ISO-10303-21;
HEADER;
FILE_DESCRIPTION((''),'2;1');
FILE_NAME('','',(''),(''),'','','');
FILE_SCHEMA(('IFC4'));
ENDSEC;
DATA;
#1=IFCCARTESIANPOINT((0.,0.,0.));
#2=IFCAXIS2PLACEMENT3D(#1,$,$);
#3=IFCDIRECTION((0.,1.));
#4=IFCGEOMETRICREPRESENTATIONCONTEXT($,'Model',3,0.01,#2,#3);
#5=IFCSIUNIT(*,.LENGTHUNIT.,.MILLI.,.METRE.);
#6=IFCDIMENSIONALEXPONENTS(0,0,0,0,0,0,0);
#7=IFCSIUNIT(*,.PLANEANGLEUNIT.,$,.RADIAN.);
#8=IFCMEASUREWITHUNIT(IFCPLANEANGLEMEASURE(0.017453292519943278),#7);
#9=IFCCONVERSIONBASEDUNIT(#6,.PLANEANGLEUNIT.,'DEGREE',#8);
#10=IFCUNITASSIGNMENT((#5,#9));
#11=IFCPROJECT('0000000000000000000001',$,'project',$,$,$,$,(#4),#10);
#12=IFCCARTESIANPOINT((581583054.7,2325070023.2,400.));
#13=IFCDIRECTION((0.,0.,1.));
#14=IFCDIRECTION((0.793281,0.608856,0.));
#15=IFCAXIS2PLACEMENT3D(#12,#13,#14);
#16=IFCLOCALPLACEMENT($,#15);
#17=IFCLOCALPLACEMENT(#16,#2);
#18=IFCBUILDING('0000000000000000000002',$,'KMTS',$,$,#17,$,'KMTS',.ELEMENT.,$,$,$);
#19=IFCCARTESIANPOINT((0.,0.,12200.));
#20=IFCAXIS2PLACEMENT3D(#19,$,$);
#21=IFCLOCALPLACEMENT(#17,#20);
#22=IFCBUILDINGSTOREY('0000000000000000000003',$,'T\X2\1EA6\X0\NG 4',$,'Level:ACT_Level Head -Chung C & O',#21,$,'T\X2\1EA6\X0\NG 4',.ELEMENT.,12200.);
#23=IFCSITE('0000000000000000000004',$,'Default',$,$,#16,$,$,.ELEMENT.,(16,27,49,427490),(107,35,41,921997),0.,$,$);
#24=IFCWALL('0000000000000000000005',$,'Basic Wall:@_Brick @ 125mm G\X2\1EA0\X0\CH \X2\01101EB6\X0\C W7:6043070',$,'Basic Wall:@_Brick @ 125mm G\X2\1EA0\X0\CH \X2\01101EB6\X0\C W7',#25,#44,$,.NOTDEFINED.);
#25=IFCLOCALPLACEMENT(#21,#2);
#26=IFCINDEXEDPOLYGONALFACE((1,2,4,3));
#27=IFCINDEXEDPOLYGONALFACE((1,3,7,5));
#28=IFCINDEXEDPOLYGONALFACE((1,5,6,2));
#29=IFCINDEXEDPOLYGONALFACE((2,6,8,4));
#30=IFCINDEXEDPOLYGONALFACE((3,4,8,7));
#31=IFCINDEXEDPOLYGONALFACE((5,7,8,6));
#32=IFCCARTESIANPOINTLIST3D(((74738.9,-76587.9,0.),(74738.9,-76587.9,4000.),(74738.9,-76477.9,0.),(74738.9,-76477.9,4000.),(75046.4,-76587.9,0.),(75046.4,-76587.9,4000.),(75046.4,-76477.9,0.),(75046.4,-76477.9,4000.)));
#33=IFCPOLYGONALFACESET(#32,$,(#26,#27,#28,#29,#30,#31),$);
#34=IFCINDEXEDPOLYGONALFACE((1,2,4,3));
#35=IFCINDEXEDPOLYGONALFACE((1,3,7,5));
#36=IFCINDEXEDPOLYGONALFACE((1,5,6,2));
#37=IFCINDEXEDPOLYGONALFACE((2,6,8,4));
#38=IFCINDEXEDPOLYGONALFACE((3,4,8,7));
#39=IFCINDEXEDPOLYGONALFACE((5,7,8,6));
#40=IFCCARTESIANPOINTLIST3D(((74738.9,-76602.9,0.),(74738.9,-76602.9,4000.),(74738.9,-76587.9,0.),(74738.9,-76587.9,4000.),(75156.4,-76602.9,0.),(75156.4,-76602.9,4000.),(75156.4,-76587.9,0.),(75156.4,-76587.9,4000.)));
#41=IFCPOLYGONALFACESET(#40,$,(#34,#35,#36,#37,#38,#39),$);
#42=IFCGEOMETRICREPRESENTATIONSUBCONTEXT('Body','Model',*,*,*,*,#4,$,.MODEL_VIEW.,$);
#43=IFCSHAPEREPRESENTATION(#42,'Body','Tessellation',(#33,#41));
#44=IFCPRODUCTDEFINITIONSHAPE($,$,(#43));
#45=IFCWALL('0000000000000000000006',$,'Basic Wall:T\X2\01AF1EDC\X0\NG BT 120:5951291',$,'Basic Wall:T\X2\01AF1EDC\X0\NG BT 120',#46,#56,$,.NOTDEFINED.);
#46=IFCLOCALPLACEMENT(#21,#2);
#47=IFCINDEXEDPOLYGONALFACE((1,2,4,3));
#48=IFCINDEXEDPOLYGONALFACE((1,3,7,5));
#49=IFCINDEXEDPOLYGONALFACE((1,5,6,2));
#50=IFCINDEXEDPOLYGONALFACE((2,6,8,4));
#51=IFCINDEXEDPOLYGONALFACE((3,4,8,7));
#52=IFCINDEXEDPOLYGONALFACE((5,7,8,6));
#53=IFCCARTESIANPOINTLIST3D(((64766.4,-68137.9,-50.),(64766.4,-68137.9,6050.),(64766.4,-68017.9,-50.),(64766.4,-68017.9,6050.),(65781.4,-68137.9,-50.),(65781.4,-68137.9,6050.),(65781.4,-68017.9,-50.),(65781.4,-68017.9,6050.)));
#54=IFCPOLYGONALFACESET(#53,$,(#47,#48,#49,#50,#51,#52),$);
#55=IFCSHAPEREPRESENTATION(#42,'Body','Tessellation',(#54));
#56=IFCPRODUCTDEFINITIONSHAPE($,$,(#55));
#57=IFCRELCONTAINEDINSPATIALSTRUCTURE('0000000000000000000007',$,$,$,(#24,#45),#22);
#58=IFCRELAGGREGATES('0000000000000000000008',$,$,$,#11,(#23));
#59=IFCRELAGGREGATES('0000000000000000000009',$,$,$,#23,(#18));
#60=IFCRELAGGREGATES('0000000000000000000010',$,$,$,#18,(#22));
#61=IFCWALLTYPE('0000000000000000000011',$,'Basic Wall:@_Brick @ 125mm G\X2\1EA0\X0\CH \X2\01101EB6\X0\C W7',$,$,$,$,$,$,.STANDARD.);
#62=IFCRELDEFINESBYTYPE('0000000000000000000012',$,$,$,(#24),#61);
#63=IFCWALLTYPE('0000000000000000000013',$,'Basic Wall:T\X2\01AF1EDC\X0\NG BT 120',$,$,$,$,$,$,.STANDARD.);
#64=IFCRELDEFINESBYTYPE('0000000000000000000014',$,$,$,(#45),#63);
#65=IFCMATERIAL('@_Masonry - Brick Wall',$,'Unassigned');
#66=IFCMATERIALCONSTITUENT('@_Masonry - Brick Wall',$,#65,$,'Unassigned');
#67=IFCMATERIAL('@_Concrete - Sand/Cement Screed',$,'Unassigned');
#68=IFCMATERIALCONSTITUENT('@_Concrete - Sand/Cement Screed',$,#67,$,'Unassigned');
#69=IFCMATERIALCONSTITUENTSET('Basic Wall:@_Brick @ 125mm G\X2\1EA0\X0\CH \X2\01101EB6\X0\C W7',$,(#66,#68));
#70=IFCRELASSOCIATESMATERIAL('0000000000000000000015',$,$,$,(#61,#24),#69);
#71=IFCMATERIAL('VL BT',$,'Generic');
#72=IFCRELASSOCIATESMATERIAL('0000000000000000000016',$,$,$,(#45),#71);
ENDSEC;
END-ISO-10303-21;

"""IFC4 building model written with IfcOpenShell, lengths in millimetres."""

from ifc_helpers import new_model, entity, si_unit, converted_unit, direction, frame, origin, place, context, subcontext, project, spatial, indexed_curve, outline, extrude, material, constituent, constituent_set, type_object, element, save


model = new_model("IFC4")

# Units and contexts
model_context = context("Model", 3, precision=0.01, world=origin(), true_north=direction((0.0, 1.0)))
body_context = subcontext(model_context, "Body", "Model", "MODEL_VIEW")
ifc_project = project(units=[si_unit("LENGTHUNIT", "METRE", prefix="MILLI"), converted_unit("PLANEANGLEUNIT", "DEGREE", entity("IfcPlaneAngleMeasure", 0.017453292519943278), si_unit("PLANEANGLEUNIT", "RADIAN"), dimensions=[0, 0, 0, 0, 0, 0, 0])], contexts=[model_context])

# Site, building, storey
site_placement = place(None, frame((581583054.7, 2325070023.2, 400.0), z_axis=(0.0, 0.0, 1.0), x_axis=(0.793281, 0.608856, 0.0)))
site = spatial("IfcSite", under=ifc_project, at=site_placement, Name="Default", CompositionType="ELEMENT", RefLatitude=(16, 27, 49, 427490), RefLongitude=(107, 35, 41, 921997), RefElevation=0.0)
building_placement = place(site_placement, origin())
building = spatial("IfcBuilding", under=site, at=building_placement, Name="KMTS", LongName="KMTS", CompositionType="ELEMENT")
storey_placement = place(building_placement, frame((0.0, 0.0, 12200.0)))
storey = spatial("IfcBuildingStorey", under=building, at=storey_placement, Name="TẦNG 4", ObjectType="Level:ACT_Level Head -Chung C & O", LongName="TẦNG 4", CompositionType="ELEMENT", Elevation=12200.0)

# Shared definitions
ifc_material_1 = material(Name="VL BT", Category="Generic")

# Walls
ifc_material_2 = material(Name="@_Masonry - Brick Wall", Category="Unassigned")
ifc_constituent_1 = constituent(ifc_material_2, Name="@_Masonry - Brick Wall", Category="Unassigned")
ifc_material_3 = material(Name="@_Concrete - Sand/Cement Screed", Category="Unassigned")
ifc_constituent_2 = constituent(ifc_material_3, Name="@_Concrete - Sand/Cement Screed", Category="Unassigned")
ifc_constituent_set_1 = constituent_set(constituents=[ifc_constituent_1, ifc_constituent_2], Name="Basic Wall:@_Brick @ 125mm GẠCH ĐẶC W7")
wall_type_1 = type_object("IfcWallType", Name="Basic Wall:@_Brick @ 125mm GẠCH ĐẶC W7", PredefinedType="STANDARD", material=ifc_constituent_set_1)
wall_1_placement = place(storey_placement, frame((75046.4, -76540.4, 0.0), z_axis=(0.0, 0.0, 1.0), x_axis=(-1.0, 0.0, 0.0)))
element("IfcWall", 1, at=wall_1_placement, inside=storey, type_object=wall_type_1, material=ifc_constituent_set_1, Name="Basic Wall:@_Brick @ 125mm GẠCH ĐẶC W7:6043070", ObjectType="Basic Wall:@_Brick @ 125mm GẠCH ĐẶC W7", PredefinedType="NOTDEFINED", context=body_context, shape_type="SweptSolid", body=[
    extrude(outline(indexed_curve([(-55.0, -153.8), (55.0, -153.7), (55.0, 153.7), (-55.0, 153.7), (-55.0, -153.8)], self_intersect=False)), frame((153.7, -7.5, 0.0), z_axis=(0.0, 0.0, 1.0), x_axis=(0.0, 1.0, 0.0)), (0.0, 0.0, 1.0), 4000.0),
    extrude(outline(indexed_curve([(-7.5, -208.8), (7.5, -208.8), (7.5, 208.8), (-7.5, 208.8), (-7.5, -208.8)], self_intersect=False)), frame((98.7, 55.0, 0.0), z_axis=(0.0, 0.0, 1.0), x_axis=(0.0, -1.0, 0.0)), (0.0, 0.0, 1.0), 4000.0),
])
wall_type_2 = type_object("IfcWallType", Name="Basic Wall:TƯỜNG BT 120", PredefinedType="STANDARD")
wall_2_placement = place(storey_placement, frame((64766.4, -68077.9, -50.0)))
element("IfcWall", 2, at=wall_2_placement, inside=storey, type_object=wall_type_2, material=ifc_material_1, Name="Basic Wall:TƯỜNG BT 120:5951291", ObjectType="Basic Wall:TƯỜNG BT 120", PredefinedType="NOTDEFINED", context=body_context, shape_type="SweptSolid", body=[
    extrude(outline(indexed_curve([(1015.0, 60.0), (0.0, 60.0), (0.0, -60.0), (1015.0, -60.0), (1015.0, 60.0)], self_intersect=False)), origin(), (0.0, 0.0, 1.0), 6100.0),
])

save(model, "model.ifc")
